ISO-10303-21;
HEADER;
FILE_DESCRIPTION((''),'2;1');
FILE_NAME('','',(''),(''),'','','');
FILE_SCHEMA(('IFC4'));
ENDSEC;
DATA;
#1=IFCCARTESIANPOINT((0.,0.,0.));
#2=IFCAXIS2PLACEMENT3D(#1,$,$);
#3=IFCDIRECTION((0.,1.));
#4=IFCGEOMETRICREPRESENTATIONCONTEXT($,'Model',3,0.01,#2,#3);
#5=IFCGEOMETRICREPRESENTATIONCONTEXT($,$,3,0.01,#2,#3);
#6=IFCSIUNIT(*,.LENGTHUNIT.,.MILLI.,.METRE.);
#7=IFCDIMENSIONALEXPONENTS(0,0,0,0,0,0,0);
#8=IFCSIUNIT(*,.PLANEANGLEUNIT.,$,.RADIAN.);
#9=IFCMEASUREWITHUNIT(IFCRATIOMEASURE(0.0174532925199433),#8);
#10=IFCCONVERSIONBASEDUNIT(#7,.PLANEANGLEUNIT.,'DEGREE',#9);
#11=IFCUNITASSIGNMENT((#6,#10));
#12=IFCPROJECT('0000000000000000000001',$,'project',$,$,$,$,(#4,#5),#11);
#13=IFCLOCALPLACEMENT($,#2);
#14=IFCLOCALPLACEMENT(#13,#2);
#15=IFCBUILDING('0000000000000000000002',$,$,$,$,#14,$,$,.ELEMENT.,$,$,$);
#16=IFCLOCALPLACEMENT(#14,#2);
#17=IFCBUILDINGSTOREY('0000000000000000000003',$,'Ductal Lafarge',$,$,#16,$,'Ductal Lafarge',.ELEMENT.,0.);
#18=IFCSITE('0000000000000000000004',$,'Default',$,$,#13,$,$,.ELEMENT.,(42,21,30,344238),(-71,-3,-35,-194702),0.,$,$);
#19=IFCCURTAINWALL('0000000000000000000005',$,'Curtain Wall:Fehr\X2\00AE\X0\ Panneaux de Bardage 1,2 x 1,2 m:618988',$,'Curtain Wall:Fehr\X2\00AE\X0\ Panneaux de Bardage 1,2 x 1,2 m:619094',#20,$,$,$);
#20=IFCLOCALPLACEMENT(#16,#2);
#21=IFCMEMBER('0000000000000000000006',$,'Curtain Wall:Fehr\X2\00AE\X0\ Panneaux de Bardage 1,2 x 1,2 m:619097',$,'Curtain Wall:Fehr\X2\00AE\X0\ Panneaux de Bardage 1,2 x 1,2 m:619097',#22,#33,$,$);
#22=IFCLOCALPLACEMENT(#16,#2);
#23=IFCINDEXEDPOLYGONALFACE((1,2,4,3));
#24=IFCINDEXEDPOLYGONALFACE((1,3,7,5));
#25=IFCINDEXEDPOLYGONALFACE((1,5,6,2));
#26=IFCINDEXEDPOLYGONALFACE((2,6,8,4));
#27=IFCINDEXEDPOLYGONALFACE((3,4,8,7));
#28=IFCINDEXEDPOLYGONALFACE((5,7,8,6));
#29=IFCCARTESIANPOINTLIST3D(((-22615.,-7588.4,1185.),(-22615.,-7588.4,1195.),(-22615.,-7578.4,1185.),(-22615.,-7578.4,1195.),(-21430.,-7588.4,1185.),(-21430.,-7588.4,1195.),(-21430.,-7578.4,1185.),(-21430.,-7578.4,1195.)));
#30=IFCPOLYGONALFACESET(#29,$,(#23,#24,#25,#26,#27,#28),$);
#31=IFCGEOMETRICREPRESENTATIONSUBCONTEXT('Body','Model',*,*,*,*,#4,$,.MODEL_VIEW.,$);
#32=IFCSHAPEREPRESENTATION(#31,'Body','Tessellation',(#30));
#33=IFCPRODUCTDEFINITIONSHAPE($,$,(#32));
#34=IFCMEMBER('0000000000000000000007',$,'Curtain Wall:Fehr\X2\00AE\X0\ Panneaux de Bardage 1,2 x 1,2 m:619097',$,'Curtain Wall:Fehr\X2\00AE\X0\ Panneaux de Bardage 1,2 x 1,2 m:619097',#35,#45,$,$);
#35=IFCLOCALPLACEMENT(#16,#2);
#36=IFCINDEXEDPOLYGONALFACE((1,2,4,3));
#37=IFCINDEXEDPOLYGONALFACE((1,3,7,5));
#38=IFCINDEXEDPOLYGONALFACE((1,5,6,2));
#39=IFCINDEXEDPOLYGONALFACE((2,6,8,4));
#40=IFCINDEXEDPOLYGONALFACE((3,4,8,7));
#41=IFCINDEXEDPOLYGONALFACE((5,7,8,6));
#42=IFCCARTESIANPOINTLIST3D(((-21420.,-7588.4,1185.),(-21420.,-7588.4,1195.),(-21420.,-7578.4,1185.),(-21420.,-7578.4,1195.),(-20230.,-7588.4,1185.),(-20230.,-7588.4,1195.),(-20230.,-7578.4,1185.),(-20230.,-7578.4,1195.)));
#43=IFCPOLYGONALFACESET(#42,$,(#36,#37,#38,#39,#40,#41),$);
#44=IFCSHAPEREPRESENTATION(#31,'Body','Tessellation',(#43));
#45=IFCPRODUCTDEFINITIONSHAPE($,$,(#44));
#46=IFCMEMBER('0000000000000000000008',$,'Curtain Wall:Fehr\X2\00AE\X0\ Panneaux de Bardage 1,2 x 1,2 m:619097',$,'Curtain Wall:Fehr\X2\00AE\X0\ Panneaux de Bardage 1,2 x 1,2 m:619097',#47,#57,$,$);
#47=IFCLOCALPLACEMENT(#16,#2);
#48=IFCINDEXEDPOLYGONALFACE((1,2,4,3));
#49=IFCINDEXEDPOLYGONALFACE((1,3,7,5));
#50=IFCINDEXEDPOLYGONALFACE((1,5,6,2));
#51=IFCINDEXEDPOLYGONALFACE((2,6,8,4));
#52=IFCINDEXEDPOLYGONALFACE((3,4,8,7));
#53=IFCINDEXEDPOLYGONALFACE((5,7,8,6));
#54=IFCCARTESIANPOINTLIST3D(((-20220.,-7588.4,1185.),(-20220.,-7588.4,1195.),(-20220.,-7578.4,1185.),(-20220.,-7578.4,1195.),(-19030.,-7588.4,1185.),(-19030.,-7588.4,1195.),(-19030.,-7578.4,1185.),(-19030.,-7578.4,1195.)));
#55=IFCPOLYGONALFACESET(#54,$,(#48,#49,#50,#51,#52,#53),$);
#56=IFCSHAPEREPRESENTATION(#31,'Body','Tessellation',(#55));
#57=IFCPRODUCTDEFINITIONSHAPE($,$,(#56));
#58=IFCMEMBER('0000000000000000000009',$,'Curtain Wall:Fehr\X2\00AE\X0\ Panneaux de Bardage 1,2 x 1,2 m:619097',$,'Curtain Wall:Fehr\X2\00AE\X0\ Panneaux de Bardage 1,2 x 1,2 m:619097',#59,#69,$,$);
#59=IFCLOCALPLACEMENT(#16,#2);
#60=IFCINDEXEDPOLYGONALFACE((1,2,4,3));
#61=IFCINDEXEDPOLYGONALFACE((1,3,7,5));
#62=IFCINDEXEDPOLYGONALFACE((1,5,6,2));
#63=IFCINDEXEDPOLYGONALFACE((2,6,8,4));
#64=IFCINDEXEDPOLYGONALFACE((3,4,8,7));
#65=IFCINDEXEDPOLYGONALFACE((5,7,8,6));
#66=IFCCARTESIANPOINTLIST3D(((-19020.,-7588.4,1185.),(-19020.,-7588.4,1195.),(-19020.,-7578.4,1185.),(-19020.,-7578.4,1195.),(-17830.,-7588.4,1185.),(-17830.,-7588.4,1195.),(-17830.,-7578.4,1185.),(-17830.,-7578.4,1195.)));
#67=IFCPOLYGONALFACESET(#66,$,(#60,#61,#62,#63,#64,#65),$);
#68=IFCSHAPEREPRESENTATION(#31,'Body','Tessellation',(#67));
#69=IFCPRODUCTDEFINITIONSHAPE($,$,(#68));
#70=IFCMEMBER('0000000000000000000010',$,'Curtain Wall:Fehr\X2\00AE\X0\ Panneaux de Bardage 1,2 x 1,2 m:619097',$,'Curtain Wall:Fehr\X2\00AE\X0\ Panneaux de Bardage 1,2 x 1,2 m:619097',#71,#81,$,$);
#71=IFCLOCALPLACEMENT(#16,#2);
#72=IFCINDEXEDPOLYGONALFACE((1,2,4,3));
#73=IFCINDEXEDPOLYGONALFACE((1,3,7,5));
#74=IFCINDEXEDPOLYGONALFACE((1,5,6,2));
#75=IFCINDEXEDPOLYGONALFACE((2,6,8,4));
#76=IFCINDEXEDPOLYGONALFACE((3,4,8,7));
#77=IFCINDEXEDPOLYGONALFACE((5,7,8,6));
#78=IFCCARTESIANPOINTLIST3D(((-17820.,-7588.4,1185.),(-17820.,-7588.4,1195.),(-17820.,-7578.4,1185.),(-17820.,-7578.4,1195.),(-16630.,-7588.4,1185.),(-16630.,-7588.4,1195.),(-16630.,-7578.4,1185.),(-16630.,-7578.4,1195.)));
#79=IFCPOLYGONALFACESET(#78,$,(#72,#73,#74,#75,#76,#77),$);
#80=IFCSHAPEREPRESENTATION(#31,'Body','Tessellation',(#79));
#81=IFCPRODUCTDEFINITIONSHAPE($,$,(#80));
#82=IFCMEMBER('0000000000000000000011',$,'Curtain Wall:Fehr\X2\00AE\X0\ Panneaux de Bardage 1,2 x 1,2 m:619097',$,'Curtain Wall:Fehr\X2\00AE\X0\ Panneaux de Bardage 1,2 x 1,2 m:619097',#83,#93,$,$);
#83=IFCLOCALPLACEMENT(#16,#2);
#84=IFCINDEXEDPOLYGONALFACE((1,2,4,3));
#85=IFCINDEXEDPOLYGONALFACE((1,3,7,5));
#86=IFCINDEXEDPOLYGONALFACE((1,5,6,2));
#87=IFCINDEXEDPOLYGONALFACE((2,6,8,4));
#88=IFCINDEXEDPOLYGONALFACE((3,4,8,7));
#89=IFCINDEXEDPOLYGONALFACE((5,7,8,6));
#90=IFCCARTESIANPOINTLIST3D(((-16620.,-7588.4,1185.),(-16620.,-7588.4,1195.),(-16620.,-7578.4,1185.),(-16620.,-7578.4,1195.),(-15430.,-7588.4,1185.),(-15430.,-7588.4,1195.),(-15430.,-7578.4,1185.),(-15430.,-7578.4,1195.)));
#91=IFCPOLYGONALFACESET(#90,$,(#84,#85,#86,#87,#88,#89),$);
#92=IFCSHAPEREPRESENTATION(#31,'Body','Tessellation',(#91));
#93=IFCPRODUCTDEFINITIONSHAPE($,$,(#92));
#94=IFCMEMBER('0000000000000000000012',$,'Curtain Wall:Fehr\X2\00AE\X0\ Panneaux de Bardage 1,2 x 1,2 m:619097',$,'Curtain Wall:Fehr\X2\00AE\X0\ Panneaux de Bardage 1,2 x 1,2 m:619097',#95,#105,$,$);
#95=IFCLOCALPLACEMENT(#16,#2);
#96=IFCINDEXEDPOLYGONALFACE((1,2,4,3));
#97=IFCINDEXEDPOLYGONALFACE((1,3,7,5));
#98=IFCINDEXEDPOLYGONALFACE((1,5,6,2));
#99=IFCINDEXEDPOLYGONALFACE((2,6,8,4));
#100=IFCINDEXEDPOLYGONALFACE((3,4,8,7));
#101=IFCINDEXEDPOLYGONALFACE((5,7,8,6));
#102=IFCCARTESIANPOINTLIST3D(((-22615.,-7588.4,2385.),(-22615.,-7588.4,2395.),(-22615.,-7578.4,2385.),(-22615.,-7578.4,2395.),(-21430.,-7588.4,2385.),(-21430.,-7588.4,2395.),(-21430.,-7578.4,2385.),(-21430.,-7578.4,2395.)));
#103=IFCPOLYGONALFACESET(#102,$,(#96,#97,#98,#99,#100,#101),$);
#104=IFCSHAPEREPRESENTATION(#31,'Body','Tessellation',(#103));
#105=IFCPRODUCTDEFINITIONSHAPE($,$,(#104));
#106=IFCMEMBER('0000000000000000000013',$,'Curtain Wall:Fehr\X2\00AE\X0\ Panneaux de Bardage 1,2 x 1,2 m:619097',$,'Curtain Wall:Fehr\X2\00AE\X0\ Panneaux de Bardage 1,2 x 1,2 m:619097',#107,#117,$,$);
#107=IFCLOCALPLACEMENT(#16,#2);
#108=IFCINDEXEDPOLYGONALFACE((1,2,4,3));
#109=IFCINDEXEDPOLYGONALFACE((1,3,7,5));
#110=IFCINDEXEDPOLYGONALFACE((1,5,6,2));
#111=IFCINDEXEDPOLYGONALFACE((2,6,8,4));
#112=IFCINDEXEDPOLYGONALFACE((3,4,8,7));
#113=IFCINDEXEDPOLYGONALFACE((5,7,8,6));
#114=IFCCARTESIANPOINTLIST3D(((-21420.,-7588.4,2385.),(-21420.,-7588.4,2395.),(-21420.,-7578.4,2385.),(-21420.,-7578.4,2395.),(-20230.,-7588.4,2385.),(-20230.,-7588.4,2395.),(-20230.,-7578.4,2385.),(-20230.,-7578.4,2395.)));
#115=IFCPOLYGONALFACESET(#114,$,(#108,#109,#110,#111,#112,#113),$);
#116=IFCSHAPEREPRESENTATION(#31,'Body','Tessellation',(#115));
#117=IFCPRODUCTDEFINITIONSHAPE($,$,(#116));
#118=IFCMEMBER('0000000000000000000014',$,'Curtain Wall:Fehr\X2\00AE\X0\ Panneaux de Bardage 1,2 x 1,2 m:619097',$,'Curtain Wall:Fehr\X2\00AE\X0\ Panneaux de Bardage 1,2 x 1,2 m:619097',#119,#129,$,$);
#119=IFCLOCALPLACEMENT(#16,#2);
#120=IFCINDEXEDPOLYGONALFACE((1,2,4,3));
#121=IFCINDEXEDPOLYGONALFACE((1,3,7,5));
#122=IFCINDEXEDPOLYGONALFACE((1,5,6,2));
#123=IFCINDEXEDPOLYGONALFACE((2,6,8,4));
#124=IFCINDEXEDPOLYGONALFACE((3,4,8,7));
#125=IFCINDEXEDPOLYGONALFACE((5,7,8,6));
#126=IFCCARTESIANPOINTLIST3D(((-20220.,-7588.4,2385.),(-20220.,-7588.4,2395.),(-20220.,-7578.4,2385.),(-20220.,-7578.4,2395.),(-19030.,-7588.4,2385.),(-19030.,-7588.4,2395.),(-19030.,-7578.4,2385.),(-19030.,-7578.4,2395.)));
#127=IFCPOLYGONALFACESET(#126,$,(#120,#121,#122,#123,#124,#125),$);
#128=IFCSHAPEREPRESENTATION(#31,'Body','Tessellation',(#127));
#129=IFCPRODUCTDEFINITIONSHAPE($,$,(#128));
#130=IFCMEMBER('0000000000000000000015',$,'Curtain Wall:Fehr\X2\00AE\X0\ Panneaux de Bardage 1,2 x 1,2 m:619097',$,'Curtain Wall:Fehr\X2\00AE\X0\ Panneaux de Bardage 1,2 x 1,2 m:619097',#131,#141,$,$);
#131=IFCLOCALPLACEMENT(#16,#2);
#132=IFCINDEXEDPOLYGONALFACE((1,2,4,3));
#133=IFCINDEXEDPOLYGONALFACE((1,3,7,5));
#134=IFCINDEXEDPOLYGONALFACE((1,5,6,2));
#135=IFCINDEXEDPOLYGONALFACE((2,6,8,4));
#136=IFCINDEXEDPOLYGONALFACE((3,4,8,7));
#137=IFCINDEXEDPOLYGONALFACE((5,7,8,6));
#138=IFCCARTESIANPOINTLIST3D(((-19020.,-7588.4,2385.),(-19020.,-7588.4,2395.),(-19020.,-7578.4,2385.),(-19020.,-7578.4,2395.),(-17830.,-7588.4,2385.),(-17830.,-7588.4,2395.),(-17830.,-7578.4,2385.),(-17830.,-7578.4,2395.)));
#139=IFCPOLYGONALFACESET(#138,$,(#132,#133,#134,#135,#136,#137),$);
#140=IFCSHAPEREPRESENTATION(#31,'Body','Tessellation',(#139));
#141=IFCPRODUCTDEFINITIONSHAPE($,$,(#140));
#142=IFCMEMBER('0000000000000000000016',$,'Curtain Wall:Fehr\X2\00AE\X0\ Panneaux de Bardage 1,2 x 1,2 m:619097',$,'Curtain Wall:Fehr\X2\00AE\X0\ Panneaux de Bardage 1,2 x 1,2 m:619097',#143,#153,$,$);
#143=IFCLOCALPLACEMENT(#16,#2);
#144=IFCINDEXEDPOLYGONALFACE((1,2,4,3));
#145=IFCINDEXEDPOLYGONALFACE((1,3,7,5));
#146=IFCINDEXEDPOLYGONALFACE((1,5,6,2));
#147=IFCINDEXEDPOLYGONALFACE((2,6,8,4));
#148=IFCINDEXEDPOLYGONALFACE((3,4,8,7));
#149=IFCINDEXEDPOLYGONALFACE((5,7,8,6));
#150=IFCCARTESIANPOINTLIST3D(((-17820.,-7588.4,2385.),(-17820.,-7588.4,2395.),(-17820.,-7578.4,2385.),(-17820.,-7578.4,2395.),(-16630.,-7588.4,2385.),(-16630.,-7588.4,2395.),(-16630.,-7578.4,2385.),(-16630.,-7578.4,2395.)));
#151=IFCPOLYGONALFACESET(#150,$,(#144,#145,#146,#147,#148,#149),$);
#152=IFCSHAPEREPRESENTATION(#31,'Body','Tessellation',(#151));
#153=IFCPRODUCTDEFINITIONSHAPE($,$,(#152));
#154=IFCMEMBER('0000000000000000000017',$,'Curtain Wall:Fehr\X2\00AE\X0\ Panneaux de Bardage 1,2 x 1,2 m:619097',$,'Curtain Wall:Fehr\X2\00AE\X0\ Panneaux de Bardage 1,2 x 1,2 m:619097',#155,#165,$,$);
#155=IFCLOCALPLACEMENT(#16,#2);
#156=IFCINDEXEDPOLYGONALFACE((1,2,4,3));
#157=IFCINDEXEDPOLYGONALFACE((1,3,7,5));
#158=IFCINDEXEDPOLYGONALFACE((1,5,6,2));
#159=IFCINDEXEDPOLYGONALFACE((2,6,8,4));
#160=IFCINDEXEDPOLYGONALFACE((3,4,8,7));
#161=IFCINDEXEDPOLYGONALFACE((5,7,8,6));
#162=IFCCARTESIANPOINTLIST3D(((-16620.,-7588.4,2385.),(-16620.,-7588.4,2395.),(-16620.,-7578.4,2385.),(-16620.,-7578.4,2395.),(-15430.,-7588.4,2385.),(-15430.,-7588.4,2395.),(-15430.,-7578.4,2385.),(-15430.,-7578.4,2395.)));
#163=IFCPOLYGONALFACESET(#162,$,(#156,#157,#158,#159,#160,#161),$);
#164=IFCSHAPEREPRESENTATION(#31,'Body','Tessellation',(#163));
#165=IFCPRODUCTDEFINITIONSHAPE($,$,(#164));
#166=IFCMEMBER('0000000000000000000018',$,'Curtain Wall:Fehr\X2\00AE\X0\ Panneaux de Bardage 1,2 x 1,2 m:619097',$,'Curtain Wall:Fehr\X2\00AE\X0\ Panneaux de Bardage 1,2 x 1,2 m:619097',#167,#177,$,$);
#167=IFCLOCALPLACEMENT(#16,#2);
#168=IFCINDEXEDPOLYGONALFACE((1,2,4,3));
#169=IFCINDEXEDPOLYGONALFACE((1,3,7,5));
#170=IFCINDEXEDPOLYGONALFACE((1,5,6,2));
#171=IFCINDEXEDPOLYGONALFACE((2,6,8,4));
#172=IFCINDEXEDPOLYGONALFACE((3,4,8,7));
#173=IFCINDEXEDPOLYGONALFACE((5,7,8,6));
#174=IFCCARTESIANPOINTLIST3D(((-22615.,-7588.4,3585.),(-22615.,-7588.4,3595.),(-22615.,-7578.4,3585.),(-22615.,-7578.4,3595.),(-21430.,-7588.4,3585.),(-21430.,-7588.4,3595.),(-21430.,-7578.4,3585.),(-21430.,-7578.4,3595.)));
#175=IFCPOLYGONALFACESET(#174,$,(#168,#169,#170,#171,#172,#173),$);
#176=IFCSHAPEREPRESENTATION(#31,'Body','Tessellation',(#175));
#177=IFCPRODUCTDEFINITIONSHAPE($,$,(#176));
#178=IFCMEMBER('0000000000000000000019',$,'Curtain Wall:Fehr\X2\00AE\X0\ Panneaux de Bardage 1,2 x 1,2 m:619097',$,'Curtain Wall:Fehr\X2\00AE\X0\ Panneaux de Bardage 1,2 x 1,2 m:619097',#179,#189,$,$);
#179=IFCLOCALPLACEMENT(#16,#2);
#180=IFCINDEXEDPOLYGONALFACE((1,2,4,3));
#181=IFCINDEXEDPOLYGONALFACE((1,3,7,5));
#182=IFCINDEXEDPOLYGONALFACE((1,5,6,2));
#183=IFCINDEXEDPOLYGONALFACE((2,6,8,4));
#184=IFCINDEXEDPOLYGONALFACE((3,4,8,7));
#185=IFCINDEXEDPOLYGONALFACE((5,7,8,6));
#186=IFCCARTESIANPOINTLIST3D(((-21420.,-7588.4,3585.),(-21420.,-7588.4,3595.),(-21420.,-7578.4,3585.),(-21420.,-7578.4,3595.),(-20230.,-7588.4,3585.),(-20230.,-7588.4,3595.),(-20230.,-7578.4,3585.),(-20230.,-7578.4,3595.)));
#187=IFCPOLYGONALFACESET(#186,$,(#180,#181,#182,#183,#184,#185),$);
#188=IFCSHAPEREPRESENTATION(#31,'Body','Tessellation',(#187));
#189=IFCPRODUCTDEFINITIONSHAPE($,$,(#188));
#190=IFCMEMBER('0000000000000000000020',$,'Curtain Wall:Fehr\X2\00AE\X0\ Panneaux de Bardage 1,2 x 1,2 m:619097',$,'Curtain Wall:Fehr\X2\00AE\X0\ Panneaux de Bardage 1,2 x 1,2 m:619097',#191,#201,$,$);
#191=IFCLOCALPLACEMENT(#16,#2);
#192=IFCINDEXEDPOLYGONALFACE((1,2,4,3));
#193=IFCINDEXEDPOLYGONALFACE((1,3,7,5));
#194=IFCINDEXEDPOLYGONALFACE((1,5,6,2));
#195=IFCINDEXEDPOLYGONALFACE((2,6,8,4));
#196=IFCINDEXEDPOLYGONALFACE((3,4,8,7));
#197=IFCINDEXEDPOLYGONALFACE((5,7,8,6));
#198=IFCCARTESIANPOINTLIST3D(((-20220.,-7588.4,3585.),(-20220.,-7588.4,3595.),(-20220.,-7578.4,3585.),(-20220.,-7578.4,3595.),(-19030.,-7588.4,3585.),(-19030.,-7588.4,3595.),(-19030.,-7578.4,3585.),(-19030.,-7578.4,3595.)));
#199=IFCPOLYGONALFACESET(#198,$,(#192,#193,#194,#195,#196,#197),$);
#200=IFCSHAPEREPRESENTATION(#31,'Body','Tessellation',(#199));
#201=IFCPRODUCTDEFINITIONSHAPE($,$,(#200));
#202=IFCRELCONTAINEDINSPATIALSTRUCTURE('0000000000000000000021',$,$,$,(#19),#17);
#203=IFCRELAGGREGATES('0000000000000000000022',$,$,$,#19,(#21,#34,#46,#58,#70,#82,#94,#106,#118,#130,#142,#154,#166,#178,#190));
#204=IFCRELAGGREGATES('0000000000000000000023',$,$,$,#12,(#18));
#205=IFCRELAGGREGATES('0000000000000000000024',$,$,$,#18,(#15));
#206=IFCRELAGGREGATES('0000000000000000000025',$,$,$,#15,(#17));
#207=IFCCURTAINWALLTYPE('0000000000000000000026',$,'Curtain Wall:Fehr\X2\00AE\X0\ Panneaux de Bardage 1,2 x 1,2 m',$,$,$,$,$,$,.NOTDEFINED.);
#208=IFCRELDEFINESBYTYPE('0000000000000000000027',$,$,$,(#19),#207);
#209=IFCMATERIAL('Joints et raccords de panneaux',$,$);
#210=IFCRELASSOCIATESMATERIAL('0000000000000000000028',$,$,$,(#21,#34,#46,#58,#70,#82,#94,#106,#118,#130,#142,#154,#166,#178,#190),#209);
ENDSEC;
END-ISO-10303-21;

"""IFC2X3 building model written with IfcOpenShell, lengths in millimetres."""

from ifc_helpers import new_model, entity, si_unit, converted_unit, direction, frame, frame_2d, origin, origin_2d_with_axis, place, context, subcontext, project, spatial, rectangle, extrude, material, type_object, element, aggregate, save


model = new_model("IFC2X3")

# Units and contexts
model_context = context("Model", 3, precision=0.01, world=origin(), true_north=direction((0.0, 1.0)))
context_of_model = context(None, 3, precision=0.01, world=origin(), true_north=direction((0.0, 1.0)))
body_context = subcontext(model_context, "Body", "Model", "MODEL_VIEW")
ifc_project = project(units=[si_unit("LENGTHUNIT", "METRE", prefix="MILLI"), converted_unit("PLANEANGLEUNIT", "DEGREE", entity("IfcRatioMeasure", 0.0174532925199433), si_unit("PLANEANGLEUNIT", "RADIAN"), dimensions=[0, 0, 0, 0, 0, 0, 0])], contexts=[model_context, context_of_model])

# Site, building, storey
site_placement = place(None, origin())
site = spatial("IfcSite", under=ifc_project, at=site_placement, Name="Default", CompositionType="ELEMENT", RefLatitude=(42, 21, 30, 344238), RefLongitude=(-71, -3, -35, -194702), RefElevation=0.0)
building_placement = place(site_placement, origin())
building = spatial("IfcBuilding", under=site, at=building_placement, CompositionType="ELEMENT")
storey_placement = place(building_placement, origin())
storey = spatial("IfcBuildingStorey", under=building, at=storey_placement, Name="Ductal Lafarge", LongName="Ductal Lafarge", CompositionType="ELEMENT", Elevation=0.0)

# Curtain wall, members
curtain_wall_type = type_object("IfcCurtainWallType", Name="Curtain Wall:Fehr® Panneaux de Bardage 1,2 x 1,2 m", PredefinedType="NOTDEFINED")
curtain_wall_placement = place(storey_placement, origin())
curtain_wall = element("IfcCurtainWall", 1, at=curtain_wall_placement, inside=storey, type_object=curtain_wall_type, Name="Curtain Wall:Fehr® Panneaux de Bardage 1,2 x 1,2 m:618988", ObjectType="Curtain Wall:Fehr® Panneaux de Bardage 1,2 x 1,2 m:619094")
ifc_material = material(Name="Joints et raccords de panneaux")
member_1_placement = place(curtain_wall_placement, frame((-22615.0, -7588.4, 1185.0)))
member_1 = element("IfcMember", 2, at=member_1_placement, material=ifc_material, Name="Curtain Wall:Fehr® Panneaux de Bardage 1,2 x 1,2 m:619097", ObjectType="Curtain Wall:Fehr® Panneaux de Bardage 1,2 x 1,2 m:619097", context=body_context, shape_type="SweptSolid", body=[
    extrude(rectangle(XDim=1185.0, YDim=10.0, at=origin_2d_with_axis()), frame((592.5, 5.0, 0.0), z_axis=(0.0, 0.0, 1.0), x_axis=(-1.0, 0.0, 0.0)), (0.0, 0.0, 1.0), 10.0),
])
member_2_placement = place(curtain_wall_placement, frame((-21420.0, -7588.4, 1185.0)))
member_2 = element("IfcMember", 3, at=member_2_placement, material=ifc_material, Name="Curtain Wall:Fehr® Panneaux de Bardage 1,2 x 1,2 m:619097", ObjectType="Curtain Wall:Fehr® Panneaux de Bardage 1,2 x 1,2 m:619097", context=body_context, shape_type="SweptSolid", body=[
    extrude(rectangle(XDim=1190.0, YDim=10.0, at=frame_2d((0.0, 0.0), x_axis=(1.0, 0.0))), frame((595.0, 5.0, 0.0), z_axis=(0.0, 0.0, 1.0), x_axis=(-1.0, 0.0, 0.0)), (0.0, 0.0, 1.0), 10.0),
])
member_3_placement = place(curtain_wall_placement, frame((-20220.0, -7588.4, 1185.0)))
member_3 = element("IfcMember", 4, at=member_3_placement, material=ifc_material, Name="Curtain Wall:Fehr® Panneaux de Bardage 1,2 x 1,2 m:619097", ObjectType="Curtain Wall:Fehr® Panneaux de Bardage 1,2 x 1,2 m:619097", context=body_context, shape_type="SweptSolid", body=[
    extrude(rectangle(XDim=1190.0, YDim=10.0, at=frame_2d((0.0, 0.0), x_axis=(1.0, 0.0))), frame((595.0, 5.0, 0.0), z_axis=(0.0, 0.0, 1.0), x_axis=(-1.0, 0.0, 0.0)), (0.0, 0.0, 1.0), 10.0),
])
member_4_placement = place(curtain_wall_placement, frame((-19020.0, -7588.4, 1185.0)))
member_4 = element("IfcMember", 5, at=member_4_placement, material=ifc_material, Name="Curtain Wall:Fehr® Panneaux de Bardage 1,2 x 1,2 m:619097", ObjectType="Curtain Wall:Fehr® Panneaux de Bardage 1,2 x 1,2 m:619097", context=body_context, shape_type="SweptSolid", body=[
    extrude(rectangle(XDim=1190.0, YDim=10.0, at=frame_2d((0.0, 0.0), x_axis=(1.0, 0.0))), frame((595.0, 5.0, 0.0), z_axis=(0.0, 0.0, 1.0), x_axis=(-1.0, 0.0, 0.0)), (0.0, 0.0, 1.0), 10.0),
])
member_5_placement = place(curtain_wall_placement, frame((-17820.0, -7588.4, 1185.0)))
member_5 = element("IfcMember", 6, at=member_5_placement, material=ifc_material, Name="Curtain Wall:Fehr® Panneaux de Bardage 1,2 x 1,2 m:619097", ObjectType="Curtain Wall:Fehr® Panneaux de Bardage 1,2 x 1,2 m:619097", context=body_context, shape_type="SweptSolid", body=[
    extrude(rectangle(XDim=1190.0, YDim=10.0, at=frame_2d((0.0, 0.0), x_axis=(1.0, 0.0))), frame((595.0, 5.0, 0.0), z_axis=(0.0, 0.0, 1.0), x_axis=(-1.0, 0.0, 0.0)), (0.0, 0.0, 1.0), 10.0),
])
member_6_placement = place(curtain_wall_placement, frame((-16620.0, -7588.4, 1185.0)))
member_6 = element("IfcMember", 7, at=member_6_placement, material=ifc_material, Name="Curtain Wall:Fehr® Panneaux de Bardage 1,2 x 1,2 m:619097", ObjectType="Curtain Wall:Fehr® Panneaux de Bardage 1,2 x 1,2 m:619097", context=body_context, shape_type="SweptSolid", body=[
    extrude(rectangle(XDim=1190.0, YDim=10.0, at=frame_2d((0.0, 0.0), x_axis=(1.0, 0.0))), frame((595.0, 5.0, 0.0), z_axis=(0.0, 0.0, 1.0), x_axis=(-1.0, 0.0, 0.0)), (0.0, 0.0, 1.0), 10.0),
])
member_7_placement = place(curtain_wall_placement, frame((-22615.0, -7588.4, 2385.0)))
member_7 = element("IfcMember", 8, at=member_7_placement, material=ifc_material, Name="Curtain Wall:Fehr® Panneaux de Bardage 1,2 x 1,2 m:619097", ObjectType="Curtain Wall:Fehr® Panneaux de Bardage 1,2 x 1,2 m:619097", context=body_context, shape_type="SweptSolid", body=[
    extrude(rectangle(XDim=1185.0, YDim=10.0, at=origin_2d_with_axis()), frame((592.5, 5.0, 0.0), z_axis=(0.0, 0.0, 1.0), x_axis=(-1.0, 0.0, 0.0)), (0.0, 0.0, 1.0), 10.0),
])
member_8_placement = place(curtain_wall_placement, frame((-21420.0, -7588.4, 2385.0)))
member_8 = element("IfcMember", 9, at=member_8_placement, material=ifc_material, Name="Curtain Wall:Fehr® Panneaux de Bardage 1,2 x 1,2 m:619097", ObjectType="Curtain Wall:Fehr® Panneaux de Bardage 1,2 x 1,2 m:619097", context=body_context, shape_type="SweptSolid", body=[
    extrude(rectangle(XDim=1190.0, YDim=10.0, at=frame_2d((0.0, 0.0), x_axis=(1.0, 0.0))), frame((595.0, 5.0, 0.0), z_axis=(0.0, 0.0, 1.0), x_axis=(-1.0, 0.0, 0.0)), (0.0, 0.0, 1.0), 10.0),
])
member_9_placement = place(curtain_wall_placement, frame((-20220.0, -7588.4, 2385.0)))
member_9 = element("IfcMember", 10, at=member_9_placement, material=ifc_material, Name="Curtain Wall:Fehr® Panneaux de Bardage 1,2 x 1,2 m:619097", ObjectType="Curtain Wall:Fehr® Panneaux de Bardage 1,2 x 1,2 m:619097", context=body_context, shape_type="SweptSolid", body=[
    extrude(rectangle(XDim=1190.0, YDim=10.0, at=frame_2d((0.0, 0.0), x_axis=(1.0, 0.0))), frame((595.0, 5.0, 0.0), z_axis=(0.0, 0.0, 1.0), x_axis=(-1.0, 0.0, 0.0)), (0.0, 0.0, 1.0), 10.0),
])
member_10_placement = place(curtain_wall_placement, frame((-19020.0, -7588.4, 2385.0)))
member_10 = element("IfcMember", 11, at=member_10_placement, material=ifc_material, Name="Curtain Wall:Fehr® Panneaux de Bardage 1,2 x 1,2 m:619097", ObjectType="Curtain Wall:Fehr® Panneaux de Bardage 1,2 x 1,2 m:619097", context=body_context, shape_type="SweptSolid", body=[
    extrude(rectangle(XDim=1190.0, YDim=10.0, at=frame_2d((0.0, 0.0), x_axis=(1.0, 0.0))), frame((595.0, 5.0, 0.0), z_axis=(0.0, 0.0, 1.0), x_axis=(-1.0, 0.0, 0.0)), (0.0, 0.0, 1.0), 10.0),
])
member_11_placement = place(curtain_wall_placement, frame((-17820.0, -7588.4, 2385.0)))
member_11 = element("IfcMember", 12, at=member_11_placement, material=ifc_material, Name="Curtain Wall:Fehr® Panneaux de Bardage 1,2 x 1,2 m:619097", ObjectType="Curtain Wall:Fehr® Panneaux de Bardage 1,2 x 1,2 m:619097", context=body_context, shape_type="SweptSolid", body=[
    extrude(rectangle(XDim=1190.0, YDim=10.0, at=frame_2d((0.0, 0.0), x_axis=(1.0, 0.0))), frame((595.0, 5.0, 0.0), z_axis=(0.0, 0.0, 1.0), x_axis=(-1.0, 0.0, 0.0)), (0.0, 0.0, 1.0), 10.0),
])
member_12_placement = place(curtain_wall_placement, frame((-16620.0, -7588.4, 2385.0)))
member_12 = element("IfcMember", 13, at=member_12_placement, material=ifc_material, Name="Curtain Wall:Fehr® Panneaux de Bardage 1,2 x 1,2 m:619097", ObjectType="Curtain Wall:Fehr® Panneaux de Bardage 1,2 x 1,2 m:619097", context=body_context, shape_type="SweptSolid", body=[
    extrude(rectangle(XDim=1190.0, YDim=10.0, at=frame_2d((0.0, 0.0), x_axis=(1.0, 0.0))), frame((595.0, 5.0, 0.0), z_axis=(0.0, 0.0, 1.0), x_axis=(-1.0, 0.0, 0.0)), (0.0, 0.0, 1.0), 10.0),
])
member_13_placement = place(curtain_wall_placement, frame((-22615.0, -7588.4, 3585.0)))
member_13 = element("IfcMember", 14, at=member_13_placement, material=ifc_material, Name="Curtain Wall:Fehr® Panneaux de Bardage 1,2 x 1,2 m:619097", ObjectType="Curtain Wall:Fehr® Panneaux de Bardage 1,2 x 1,2 m:619097", context=body_context, shape_type="SweptSolid", body=[
    extrude(rectangle(XDim=1185.0, YDim=10.0, at=origin_2d_with_axis()), frame((592.5, 5.0, 0.0), z_axis=(0.0, 0.0, 1.0), x_axis=(-1.0, 0.0, 0.0)), (0.0, 0.0, 1.0), 10.0),
])
member_14_placement = place(curtain_wall_placement, frame((-21420.0, -7588.4, 3585.0)))
member_14 = element("IfcMember", 15, at=member_14_placement, material=ifc_material, Name="Curtain Wall:Fehr® Panneaux de Bardage 1,2 x 1,2 m:619097", ObjectType="Curtain Wall:Fehr® Panneaux de Bardage 1,2 x 1,2 m:619097", context=body_context, shape_type="SweptSolid", body=[
    extrude(rectangle(XDim=1190.0, YDim=10.0, at=frame_2d((0.0, 0.0), x_axis=(1.0, 0.0))), frame((595.0, 5.0, 0.0), z_axis=(0.0, 0.0, 1.0), x_axis=(-1.0, 0.0, 0.0)), (0.0, 0.0, 1.0), 10.0),
])
member_15_placement = place(curtain_wall_placement, frame((-20220.0, -7588.4, 3585.0)))
member_15 = element("IfcMember", 16, at=member_15_placement, material=ifc_material, Name="Curtain Wall:Fehr® Panneaux de Bardage 1,2 x 1,2 m:619097", ObjectType="Curtain Wall:Fehr® Panneaux de Bardage 1,2 x 1,2 m:619097", context=body_context, shape_type="SweptSolid", body=[
    extrude(rectangle(XDim=1190.0, YDim=10.0, at=frame_2d((0.0, 0.0), x_axis=(1.0, 0.0))), frame((595.0, 5.0, 0.0), z_axis=(0.0, 0.0, 1.0), x_axis=(-1.0, 0.0, 0.0)), (0.0, 0.0, 1.0), 10.0),
])
aggregate(curtain_wall, [member_1, member_2, member_3, member_4, member_5, member_6, member_7, member_8, member_9, member_10, member_11, member_12, member_13, member_14, member_15])

save(model, "model.ifc")
